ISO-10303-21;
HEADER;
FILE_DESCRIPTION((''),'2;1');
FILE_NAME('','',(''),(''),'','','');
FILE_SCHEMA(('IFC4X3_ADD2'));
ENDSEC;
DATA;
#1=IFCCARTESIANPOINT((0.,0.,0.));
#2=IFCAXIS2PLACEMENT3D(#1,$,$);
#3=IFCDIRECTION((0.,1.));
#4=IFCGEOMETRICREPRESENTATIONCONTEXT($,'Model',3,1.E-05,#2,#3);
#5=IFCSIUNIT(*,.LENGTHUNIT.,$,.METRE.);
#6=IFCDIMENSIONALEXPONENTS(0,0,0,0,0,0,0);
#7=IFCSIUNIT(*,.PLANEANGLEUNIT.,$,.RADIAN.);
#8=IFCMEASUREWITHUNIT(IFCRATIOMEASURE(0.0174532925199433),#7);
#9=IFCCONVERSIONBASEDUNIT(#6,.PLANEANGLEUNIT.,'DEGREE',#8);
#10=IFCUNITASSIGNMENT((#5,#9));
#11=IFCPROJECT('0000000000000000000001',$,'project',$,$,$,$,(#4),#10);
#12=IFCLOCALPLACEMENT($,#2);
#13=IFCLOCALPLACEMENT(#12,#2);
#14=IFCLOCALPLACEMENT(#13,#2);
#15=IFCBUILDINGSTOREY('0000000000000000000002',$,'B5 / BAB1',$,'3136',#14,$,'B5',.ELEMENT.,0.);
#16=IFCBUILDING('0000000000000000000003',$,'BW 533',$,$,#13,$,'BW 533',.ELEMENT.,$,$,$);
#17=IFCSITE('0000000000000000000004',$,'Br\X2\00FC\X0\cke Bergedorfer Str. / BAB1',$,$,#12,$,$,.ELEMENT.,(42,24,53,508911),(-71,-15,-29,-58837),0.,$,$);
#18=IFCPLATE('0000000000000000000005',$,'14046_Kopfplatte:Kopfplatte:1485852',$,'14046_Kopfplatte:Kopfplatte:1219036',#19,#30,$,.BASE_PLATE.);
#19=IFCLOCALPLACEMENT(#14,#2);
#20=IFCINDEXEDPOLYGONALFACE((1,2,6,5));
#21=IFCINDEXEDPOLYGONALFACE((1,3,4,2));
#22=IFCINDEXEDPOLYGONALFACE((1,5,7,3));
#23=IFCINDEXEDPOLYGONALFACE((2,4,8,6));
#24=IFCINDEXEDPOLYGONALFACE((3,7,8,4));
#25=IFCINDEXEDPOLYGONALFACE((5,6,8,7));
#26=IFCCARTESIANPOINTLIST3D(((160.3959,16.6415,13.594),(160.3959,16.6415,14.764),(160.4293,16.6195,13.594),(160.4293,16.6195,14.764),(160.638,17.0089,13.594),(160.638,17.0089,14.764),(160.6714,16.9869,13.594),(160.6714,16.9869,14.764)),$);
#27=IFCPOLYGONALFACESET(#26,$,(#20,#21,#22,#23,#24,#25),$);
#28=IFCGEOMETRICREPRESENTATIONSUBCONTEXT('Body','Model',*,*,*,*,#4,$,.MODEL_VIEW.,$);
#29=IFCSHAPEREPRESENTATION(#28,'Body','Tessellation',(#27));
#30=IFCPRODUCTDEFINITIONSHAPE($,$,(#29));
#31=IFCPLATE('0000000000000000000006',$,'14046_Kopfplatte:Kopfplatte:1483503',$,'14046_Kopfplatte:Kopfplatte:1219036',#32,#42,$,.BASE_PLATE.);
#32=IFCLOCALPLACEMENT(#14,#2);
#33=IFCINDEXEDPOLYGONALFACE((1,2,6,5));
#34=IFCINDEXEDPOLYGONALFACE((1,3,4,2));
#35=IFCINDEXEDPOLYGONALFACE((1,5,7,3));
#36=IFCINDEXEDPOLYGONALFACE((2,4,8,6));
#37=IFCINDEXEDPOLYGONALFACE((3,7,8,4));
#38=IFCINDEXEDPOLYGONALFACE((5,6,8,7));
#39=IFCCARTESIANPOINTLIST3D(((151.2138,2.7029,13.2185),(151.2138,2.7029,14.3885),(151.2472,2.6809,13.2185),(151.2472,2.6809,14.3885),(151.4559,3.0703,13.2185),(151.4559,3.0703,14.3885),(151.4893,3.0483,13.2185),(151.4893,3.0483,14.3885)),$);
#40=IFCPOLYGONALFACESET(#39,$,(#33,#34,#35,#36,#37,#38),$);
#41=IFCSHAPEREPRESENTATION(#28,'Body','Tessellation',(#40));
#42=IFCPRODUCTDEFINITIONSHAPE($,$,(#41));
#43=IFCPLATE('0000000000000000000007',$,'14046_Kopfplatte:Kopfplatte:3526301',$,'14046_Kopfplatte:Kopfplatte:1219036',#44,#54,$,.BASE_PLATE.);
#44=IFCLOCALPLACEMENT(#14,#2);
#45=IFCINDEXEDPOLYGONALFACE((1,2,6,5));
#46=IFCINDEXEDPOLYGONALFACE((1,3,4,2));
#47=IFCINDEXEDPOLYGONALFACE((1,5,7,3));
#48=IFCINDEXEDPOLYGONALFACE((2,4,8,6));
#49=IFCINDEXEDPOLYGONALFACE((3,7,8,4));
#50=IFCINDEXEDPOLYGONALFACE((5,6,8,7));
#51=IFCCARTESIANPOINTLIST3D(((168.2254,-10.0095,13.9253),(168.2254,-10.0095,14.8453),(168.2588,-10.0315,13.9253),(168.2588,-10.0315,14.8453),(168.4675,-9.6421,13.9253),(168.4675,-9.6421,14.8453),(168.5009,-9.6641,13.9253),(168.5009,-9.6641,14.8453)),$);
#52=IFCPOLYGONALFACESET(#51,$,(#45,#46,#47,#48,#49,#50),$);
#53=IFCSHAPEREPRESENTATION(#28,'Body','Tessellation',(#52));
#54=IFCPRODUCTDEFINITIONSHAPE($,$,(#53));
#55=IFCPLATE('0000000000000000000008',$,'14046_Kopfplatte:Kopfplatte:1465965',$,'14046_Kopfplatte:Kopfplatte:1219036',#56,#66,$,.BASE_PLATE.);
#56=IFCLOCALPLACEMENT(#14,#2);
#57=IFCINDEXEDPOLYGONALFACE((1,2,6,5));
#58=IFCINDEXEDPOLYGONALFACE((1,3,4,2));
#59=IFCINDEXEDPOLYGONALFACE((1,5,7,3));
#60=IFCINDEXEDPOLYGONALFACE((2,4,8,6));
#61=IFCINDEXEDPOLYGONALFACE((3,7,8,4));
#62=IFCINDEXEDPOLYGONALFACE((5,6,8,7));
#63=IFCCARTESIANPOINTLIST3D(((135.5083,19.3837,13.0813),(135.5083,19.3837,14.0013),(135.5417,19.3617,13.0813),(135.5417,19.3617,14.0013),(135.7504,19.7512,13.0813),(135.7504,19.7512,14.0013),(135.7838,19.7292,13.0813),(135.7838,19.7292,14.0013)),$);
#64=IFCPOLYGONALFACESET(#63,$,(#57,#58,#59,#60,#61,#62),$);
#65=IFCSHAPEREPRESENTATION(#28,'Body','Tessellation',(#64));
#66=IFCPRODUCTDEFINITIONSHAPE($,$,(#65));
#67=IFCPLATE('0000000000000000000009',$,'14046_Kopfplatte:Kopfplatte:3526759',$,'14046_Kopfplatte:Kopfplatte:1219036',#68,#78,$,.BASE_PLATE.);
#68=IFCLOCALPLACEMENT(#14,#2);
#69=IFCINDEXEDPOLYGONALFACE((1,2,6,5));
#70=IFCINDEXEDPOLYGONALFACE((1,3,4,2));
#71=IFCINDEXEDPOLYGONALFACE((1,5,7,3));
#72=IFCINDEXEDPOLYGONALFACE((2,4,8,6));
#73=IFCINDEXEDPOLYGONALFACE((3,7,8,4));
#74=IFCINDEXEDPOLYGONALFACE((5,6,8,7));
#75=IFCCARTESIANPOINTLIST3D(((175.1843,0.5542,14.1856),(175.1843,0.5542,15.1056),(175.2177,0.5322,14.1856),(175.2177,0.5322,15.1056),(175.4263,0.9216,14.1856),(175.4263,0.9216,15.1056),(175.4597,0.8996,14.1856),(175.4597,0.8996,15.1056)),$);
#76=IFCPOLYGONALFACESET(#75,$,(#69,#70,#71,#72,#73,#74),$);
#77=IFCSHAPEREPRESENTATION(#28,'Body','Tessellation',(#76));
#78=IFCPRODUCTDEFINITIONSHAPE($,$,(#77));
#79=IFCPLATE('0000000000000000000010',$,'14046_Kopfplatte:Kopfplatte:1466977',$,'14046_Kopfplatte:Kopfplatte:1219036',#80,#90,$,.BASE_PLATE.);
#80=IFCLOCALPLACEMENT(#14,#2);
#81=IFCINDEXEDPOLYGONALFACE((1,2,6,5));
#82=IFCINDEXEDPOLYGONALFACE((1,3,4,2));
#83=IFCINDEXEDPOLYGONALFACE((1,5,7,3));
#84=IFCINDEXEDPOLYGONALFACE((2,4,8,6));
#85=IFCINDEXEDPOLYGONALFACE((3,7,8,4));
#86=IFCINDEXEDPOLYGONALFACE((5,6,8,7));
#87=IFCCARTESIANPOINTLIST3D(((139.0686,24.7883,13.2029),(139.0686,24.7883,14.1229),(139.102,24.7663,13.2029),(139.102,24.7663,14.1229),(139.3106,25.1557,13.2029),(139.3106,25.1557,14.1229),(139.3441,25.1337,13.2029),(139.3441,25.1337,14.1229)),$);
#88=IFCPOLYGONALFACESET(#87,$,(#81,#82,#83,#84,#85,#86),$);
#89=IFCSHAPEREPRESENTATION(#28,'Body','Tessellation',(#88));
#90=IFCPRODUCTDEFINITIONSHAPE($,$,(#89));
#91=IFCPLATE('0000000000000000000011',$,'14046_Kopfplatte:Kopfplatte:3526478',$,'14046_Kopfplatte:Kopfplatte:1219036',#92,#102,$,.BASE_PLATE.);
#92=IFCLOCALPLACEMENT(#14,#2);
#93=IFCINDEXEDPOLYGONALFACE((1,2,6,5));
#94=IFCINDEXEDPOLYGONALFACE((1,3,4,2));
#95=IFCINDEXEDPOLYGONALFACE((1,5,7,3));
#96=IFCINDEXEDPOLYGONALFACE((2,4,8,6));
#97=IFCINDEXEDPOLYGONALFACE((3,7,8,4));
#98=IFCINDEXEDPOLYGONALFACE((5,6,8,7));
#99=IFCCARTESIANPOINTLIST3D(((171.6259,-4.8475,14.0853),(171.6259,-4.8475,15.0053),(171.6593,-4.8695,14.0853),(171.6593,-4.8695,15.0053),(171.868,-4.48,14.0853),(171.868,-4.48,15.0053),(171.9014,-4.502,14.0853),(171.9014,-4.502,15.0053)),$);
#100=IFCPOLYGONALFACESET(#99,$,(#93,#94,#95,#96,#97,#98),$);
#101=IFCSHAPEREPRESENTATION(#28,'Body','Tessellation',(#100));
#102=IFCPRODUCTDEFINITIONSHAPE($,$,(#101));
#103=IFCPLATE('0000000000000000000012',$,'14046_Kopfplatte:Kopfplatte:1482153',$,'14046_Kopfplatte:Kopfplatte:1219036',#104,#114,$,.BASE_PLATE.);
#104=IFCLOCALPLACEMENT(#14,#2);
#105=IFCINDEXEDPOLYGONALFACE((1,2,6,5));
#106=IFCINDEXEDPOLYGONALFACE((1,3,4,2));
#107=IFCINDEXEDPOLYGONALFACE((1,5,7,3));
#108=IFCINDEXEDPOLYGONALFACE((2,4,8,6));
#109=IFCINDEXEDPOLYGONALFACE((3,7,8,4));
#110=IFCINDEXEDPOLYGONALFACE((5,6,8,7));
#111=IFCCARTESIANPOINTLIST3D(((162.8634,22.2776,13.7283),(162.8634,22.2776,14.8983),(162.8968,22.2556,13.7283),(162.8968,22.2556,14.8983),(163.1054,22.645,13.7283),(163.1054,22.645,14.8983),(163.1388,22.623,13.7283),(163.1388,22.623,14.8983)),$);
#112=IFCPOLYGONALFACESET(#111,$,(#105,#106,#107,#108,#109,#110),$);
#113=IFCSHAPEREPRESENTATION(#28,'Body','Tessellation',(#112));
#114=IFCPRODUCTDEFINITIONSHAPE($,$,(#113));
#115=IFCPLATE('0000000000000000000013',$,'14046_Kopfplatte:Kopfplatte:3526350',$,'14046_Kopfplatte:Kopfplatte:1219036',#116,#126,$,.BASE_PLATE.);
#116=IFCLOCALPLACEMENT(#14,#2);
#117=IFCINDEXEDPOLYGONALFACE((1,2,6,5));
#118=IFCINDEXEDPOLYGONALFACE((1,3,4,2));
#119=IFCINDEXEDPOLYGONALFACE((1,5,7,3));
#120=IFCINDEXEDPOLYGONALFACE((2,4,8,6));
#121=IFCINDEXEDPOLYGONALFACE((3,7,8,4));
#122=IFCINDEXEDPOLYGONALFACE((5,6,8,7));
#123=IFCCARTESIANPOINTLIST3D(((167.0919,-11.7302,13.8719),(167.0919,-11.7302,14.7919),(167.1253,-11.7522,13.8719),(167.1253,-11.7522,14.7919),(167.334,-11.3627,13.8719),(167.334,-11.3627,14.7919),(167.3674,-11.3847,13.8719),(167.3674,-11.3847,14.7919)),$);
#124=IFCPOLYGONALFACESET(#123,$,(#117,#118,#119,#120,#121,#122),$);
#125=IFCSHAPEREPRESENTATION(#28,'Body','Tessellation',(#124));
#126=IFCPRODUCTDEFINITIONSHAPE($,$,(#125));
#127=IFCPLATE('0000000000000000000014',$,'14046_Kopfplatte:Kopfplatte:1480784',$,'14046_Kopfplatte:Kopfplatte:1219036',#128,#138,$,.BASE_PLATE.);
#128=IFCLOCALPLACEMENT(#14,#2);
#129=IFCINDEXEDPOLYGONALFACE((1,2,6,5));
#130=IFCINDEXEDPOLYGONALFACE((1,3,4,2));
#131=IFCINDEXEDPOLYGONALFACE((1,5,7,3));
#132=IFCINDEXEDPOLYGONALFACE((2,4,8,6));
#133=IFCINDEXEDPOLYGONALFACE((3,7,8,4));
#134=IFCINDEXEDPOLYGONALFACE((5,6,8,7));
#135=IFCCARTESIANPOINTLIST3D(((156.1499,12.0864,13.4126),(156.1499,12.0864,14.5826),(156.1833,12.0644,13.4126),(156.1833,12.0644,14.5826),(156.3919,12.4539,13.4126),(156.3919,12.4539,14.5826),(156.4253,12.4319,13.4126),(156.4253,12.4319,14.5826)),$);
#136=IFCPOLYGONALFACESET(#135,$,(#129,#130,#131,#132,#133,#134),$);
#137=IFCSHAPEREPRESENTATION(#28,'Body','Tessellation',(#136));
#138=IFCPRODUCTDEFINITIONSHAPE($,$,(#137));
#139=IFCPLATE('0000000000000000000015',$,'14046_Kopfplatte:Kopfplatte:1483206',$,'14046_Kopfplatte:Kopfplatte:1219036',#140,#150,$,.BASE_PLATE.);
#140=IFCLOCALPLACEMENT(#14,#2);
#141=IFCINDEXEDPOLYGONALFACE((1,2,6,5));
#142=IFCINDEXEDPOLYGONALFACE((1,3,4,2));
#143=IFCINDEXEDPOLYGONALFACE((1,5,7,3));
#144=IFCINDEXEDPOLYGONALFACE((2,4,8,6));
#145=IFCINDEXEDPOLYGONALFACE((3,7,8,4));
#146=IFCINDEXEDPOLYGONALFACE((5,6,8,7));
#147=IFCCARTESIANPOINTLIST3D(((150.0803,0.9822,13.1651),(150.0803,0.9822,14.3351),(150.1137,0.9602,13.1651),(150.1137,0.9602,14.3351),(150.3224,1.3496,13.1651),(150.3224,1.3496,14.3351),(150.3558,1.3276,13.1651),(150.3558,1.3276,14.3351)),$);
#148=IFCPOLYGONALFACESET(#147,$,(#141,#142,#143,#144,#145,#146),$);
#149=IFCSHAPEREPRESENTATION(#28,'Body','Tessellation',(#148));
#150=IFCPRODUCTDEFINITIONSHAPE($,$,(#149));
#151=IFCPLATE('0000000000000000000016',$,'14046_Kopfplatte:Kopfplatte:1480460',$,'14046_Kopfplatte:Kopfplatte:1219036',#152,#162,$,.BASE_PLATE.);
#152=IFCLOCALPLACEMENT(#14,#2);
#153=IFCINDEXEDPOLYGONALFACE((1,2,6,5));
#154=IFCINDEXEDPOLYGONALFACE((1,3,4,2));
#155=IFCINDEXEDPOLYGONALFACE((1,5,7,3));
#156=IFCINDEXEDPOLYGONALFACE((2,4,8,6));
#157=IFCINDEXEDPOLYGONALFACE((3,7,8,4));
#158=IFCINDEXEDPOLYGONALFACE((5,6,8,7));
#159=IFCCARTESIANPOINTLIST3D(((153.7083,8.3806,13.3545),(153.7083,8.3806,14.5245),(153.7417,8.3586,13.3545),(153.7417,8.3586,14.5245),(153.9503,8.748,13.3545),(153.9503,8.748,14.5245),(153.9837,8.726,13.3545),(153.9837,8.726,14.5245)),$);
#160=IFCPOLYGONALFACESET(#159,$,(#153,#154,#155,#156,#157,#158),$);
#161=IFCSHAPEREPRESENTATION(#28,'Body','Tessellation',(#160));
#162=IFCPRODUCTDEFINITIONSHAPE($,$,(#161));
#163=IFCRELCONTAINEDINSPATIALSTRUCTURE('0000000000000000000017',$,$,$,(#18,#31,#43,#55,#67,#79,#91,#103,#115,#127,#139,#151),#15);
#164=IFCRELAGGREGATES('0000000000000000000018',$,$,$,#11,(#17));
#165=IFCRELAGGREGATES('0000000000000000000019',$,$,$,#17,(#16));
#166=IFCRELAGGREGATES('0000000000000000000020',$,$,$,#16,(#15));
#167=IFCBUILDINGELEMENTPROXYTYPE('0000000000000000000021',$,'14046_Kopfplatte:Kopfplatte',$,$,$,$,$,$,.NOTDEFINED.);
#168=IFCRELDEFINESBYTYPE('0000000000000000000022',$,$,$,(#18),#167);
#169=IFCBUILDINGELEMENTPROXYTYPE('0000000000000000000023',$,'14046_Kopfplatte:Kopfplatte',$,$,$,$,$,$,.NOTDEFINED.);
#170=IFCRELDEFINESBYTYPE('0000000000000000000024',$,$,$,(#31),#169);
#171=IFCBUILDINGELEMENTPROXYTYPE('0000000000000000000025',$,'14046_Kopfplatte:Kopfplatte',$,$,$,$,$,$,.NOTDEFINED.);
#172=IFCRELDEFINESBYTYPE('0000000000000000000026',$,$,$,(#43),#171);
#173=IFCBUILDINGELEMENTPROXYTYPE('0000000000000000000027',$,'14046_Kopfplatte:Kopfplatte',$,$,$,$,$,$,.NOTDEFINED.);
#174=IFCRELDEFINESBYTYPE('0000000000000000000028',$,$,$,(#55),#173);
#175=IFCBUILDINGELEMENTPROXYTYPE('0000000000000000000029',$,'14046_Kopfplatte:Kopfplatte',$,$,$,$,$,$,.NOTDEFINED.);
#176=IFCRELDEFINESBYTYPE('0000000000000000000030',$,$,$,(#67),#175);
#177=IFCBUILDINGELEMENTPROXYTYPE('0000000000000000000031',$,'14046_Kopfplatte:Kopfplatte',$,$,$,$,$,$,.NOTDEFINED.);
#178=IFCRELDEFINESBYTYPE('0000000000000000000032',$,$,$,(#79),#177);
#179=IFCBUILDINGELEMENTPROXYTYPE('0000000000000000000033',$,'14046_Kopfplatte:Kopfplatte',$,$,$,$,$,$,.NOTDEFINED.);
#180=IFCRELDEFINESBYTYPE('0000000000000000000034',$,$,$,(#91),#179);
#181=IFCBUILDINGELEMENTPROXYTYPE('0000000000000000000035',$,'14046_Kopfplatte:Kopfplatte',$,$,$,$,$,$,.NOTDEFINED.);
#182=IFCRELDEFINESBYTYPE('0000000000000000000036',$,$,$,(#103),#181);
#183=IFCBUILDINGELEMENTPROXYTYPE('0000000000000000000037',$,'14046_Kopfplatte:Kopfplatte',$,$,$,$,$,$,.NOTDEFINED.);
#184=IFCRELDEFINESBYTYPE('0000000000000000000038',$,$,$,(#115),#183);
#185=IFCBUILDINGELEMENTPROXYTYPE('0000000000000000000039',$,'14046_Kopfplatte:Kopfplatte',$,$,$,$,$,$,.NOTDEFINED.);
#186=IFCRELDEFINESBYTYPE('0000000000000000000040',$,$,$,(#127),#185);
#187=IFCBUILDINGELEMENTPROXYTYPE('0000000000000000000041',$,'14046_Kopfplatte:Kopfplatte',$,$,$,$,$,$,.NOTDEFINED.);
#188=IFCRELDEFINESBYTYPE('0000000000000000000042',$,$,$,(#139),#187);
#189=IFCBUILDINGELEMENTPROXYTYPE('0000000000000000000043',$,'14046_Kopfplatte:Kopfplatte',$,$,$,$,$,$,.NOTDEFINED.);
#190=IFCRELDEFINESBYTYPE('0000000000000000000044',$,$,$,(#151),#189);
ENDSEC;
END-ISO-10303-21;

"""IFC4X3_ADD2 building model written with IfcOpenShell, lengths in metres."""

from ifc_helpers import new_model, entity, si_unit, converted_unit, direction, frame, frame_2d, origin, origin_2d_with_axis, place, context, subcontext, project, spatial, rectangle, extrude, source, transform, mapped, type_object, type_shapes, element, save


model = new_model("IFC4X3_ADD2")

# Units and contexts
model_context = context("Model", 3, precision=1e-05, world=origin(), true_north=direction((0.0, 1.0)))
body_context = subcontext(model_context, "Body", "Model", "MODEL_VIEW")
ifc_project = project(units=[si_unit("LENGTHUNIT", "METRE"), converted_unit("PLANEANGLEUNIT", "DEGREE", entity("IfcRatioMeasure", 0.0174532925199433), si_unit("PLANEANGLEUNIT", "RADIAN"), dimensions=[0, 0, 0, 0, 0, 0, 0])], contexts=[model_context])

# Site, building, storey
site_placement = place(None, origin())
site = spatial("IfcSite", under=ifc_project, at=site_placement, Name="Brücke Bergedorfer Str. / BAB1", CompositionType="ELEMENT", RefLatitude=(42, 24, 53, 508911), RefLongitude=(-71, -15, -29, -58837), RefElevation=0.0)
building_placement = place(site_placement, origin())
building = spatial("IfcBuilding", under=site, at=building_placement, Name="BW 533", LongName="BW 533", CompositionType="ELEMENT")
storey_placement = place(building_placement, origin())
storey = spatial("IfcBuildingStorey", under=building, at=storey_placement, Name="B5 / BAB1", ObjectType="3136", LongName="B5", CompositionType="ELEMENT", Elevation=0.0)

# Plates
building_element_proxy_type_1 = type_object("IfcBuildingElementProxyType", Name="14046_Kopfplatte:Kopfplatte", PredefinedType="NOTDEFINED")
shared_shape_1 = source(origin(), body_context, "Body", "SweptSolid", [
    extrude(rectangle(XDim=0.04, YDim=0.44, at=frame_2d((0.0, 0.0), x_axis=(1.0, 0.0))), frame((160.5336, 16.8142, 13.594), z_axis=(0.0, 0.0, 1.0), x_axis=(-0.835088, 0.550116, 0.0)), (0.0, 0.0, 1.0), 1.17),
])
type_shapes(building_element_proxy_type_1, [shared_shape_1])
plate_1_placement = place(storey_placement, origin())
element("IfcPlate", 1, at=plate_1_placement, inside=storey, type_object=building_element_proxy_type_1, Name="14046_Kopfplatte:Kopfplatte:1485852", ObjectType="14046_Kopfplatte:Kopfplatte:1219036", PredefinedType="BASE_PLATE", context=body_context, shape_type="MappedRepresentation", body=[
    mapped(shared_shape_1, transform((0.0, 0.0, 0.0), scale=1.0)),
])
building_element_proxy_type_2 = type_object("IfcBuildingElementProxyType", Name="14046_Kopfplatte:Kopfplatte", PredefinedType="NOTDEFINED")
shared_shape_2 = source(origin(), body_context, "Body", "SweptSolid", [
    extrude(rectangle(XDim=0.04, YDim=0.44, at=frame_2d((0.0, 0.0), x_axis=(1.0, 0.0))), frame((151.3516, 2.8756, 13.2185), z_axis=(0.0, 0.0, 1.0), x_axis=(-0.835088, 0.550116, 0.0)), (0.0, 0.0, 1.0), 1.17),
])
type_shapes(building_element_proxy_type_2, [shared_shape_2])
plate_2_placement = place(storey_placement, origin())
element("IfcPlate", 2, at=plate_2_placement, inside=storey, type_object=building_element_proxy_type_2, Name="14046_Kopfplatte:Kopfplatte:1483503", ObjectType="14046_Kopfplatte:Kopfplatte:1219036", PredefinedType="BASE_PLATE", context=body_context, shape_type="MappedRepresentation", body=[
    mapped(shared_shape_2, transform((0.0, 0.0, 0.0), scale=1.0)),
])
building_element_proxy_type_3 = type_object("IfcBuildingElementProxyType", Name="14046_Kopfplatte:Kopfplatte", PredefinedType="NOTDEFINED")
shared_shape_3 = source(origin(), body_context, "Body", "SweptSolid", [
    extrude(rectangle(XDim=0.04, YDim=0.44, at=frame_2d((0.0, 0.0), x_axis=(1.0, 0.0))), frame((168.3631, -9.8368, 13.9253), z_axis=(0.0, 0.0, 1.0), x_axis=(0.835088, -0.550116, 0.0)), (0.0, 0.0, 1.0), 0.92),
])
type_shapes(building_element_proxy_type_3, [shared_shape_3])
plate_3_placement = place(storey_placement, origin())
element("IfcPlate", 3, at=plate_3_placement, inside=storey, type_object=building_element_proxy_type_3, Name="14046_Kopfplatte:Kopfplatte:3526301", ObjectType="14046_Kopfplatte:Kopfplatte:1219036", PredefinedType="BASE_PLATE", context=body_context, shape_type="MappedRepresentation", body=[
    mapped(shared_shape_3, transform((0.0, 0.0, 0.0), scale=1.0)),
])
building_element_proxy_type_4 = type_object("IfcBuildingElementProxyType", Name="14046_Kopfplatte:Kopfplatte", PredefinedType="NOTDEFINED")
shared_shape_4 = source(origin(), body_context, "Body", "SweptSolid", [
    extrude(rectangle(XDim=0.04, YDim=0.44, at=frame_2d((0.0, 0.0), x_axis=(1.0, 0.0))), frame((135.6461, 19.5565, 13.0813), z_axis=(0.0, 0.0, 1.0), x_axis=(-0.835088, 0.550116, 0.0)), (0.0, 0.0, 1.0), 0.92),
])
type_shapes(building_element_proxy_type_4, [shared_shape_4])
plate_4_placement = place(storey_placement, origin())
element("IfcPlate", 4, at=plate_4_placement, inside=storey, type_object=building_element_proxy_type_4, Name="14046_Kopfplatte:Kopfplatte:1465965", ObjectType="14046_Kopfplatte:Kopfplatte:1219036", PredefinedType="BASE_PLATE", context=body_context, shape_type="MappedRepresentation", body=[
    mapped(shared_shape_4, transform((0.0, 0.0, 0.0), scale=1.0)),
])
building_element_proxy_type_5 = type_object("IfcBuildingElementProxyType", Name="14046_Kopfplatte:Kopfplatte", PredefinedType="NOTDEFINED")
shared_shape_5 = source(origin(), body_context, "Body", "SweptSolid", [
    extrude(rectangle(XDim=0.04, YDim=0.44, at=frame_2d((0.0, 0.0), x_axis=(1.0, 0.0))), frame((175.322, 0.7269, 14.1856), z_axis=(0.0, 0.0, 1.0), x_axis=(0.835088, -0.550116, 0.0)), (0.0, 0.0, 1.0), 0.92),
])
type_shapes(building_element_proxy_type_5, [shared_shape_5])
plate_5_placement = place(storey_placement, origin())
element("IfcPlate", 5, at=plate_5_placement, inside=storey, type_object=building_element_proxy_type_5, Name="14046_Kopfplatte:Kopfplatte:3526759", ObjectType="14046_Kopfplatte:Kopfplatte:1219036", PredefinedType="BASE_PLATE", context=body_context, shape_type="MappedRepresentation", body=[
    mapped(shared_shape_5, transform((0.0, 0.0, 0.0), scale=1.0)),
])
building_element_proxy_type_6 = type_object("IfcBuildingElementProxyType", Name="14046_Kopfplatte:Kopfplatte", PredefinedType="NOTDEFINED")
shared_shape_6 = source(origin(), body_context, "Body", "SweptSolid", [
    extrude(rectangle(XDim=0.04, YDim=0.44, at=frame_2d((0.0, 0.0), x_axis=(1.0, 0.0))), frame((139.2063, 24.961, 13.2029), z_axis=(0.0, 0.0, 1.0), x_axis=(-0.835088, 0.550116, 0.0)), (0.0, 0.0, 1.0), 0.92),
])
type_shapes(building_element_proxy_type_6, [shared_shape_6])
plate_6_placement = place(storey_placement, origin())
element("IfcPlate", 6, at=plate_6_placement, inside=storey, type_object=building_element_proxy_type_6, Name="14046_Kopfplatte:Kopfplatte:1466977", ObjectType="14046_Kopfplatte:Kopfplatte:1219036", PredefinedType="BASE_PLATE", context=body_context, shape_type="MappedRepresentation", body=[
    mapped(shared_shape_6, transform((0.0, 0.0, 0.0), scale=1.0)),
])
building_element_proxy_type_7 = type_object("IfcBuildingElementProxyType", Name="14046_Kopfplatte:Kopfplatte", PredefinedType="NOTDEFINED")
shared_shape_7 = source(origin(), body_context, "Body", "SweptSolid", [
    extrude(rectangle(XDim=0.04, YDim=0.44, at=frame_2d((0.0, 0.0), x_axis=(1.0, 0.0))), frame((171.7636, -4.6748, 14.0853), z_axis=(0.0, 0.0, 1.0), x_axis=(0.835088, -0.550116, 0.0)), (0.0, 0.0, 1.0), 0.92),
])
type_shapes(building_element_proxy_type_7, [shared_shape_7])
plate_7_placement = place(storey_placement, origin())
element("IfcPlate", 7, at=plate_7_placement, inside=storey, type_object=building_element_proxy_type_7, Name="14046_Kopfplatte:Kopfplatte:3526478", ObjectType="14046_Kopfplatte:Kopfplatte:1219036", PredefinedType="BASE_PLATE", context=body_context, shape_type="MappedRepresentation", body=[
    mapped(shared_shape_7, transform((0.0, 0.0, 0.0), scale=1.0)),
])
building_element_proxy_type_8 = type_object("IfcBuildingElementProxyType", Name="14046_Kopfplatte:Kopfplatte", PredefinedType="NOTDEFINED")
shared_shape_8 = source(origin(), body_context, "Body", "SweptSolid", [
    extrude(rectangle(XDim=0.04, YDim=0.44, at=frame_2d((0.0, 0.0), x_axis=(1.0, 0.0))), frame((163.0011, 22.4503, 13.7283), z_axis=(0.0, 0.0, 1.0), x_axis=(0.835088, -0.550116, 0.0)), (0.0, 0.0, 1.0), 1.17),
])
type_shapes(building_element_proxy_type_8, [shared_shape_8])
plate_8_placement = place(storey_placement, origin())
element("IfcPlate", 8, at=plate_8_placement, inside=storey, type_object=building_element_proxy_type_8, Name="14046_Kopfplatte:Kopfplatte:1482153", ObjectType="14046_Kopfplatte:Kopfplatte:1219036", PredefinedType="BASE_PLATE", context=body_context, shape_type="MappedRepresentation", body=[
    mapped(shared_shape_8, transform((0.0, 0.0, 0.0), scale=1.0)),
])
building_element_proxy_type_9 = type_object("IfcBuildingElementProxyType", Name="14046_Kopfplatte:Kopfplatte", PredefinedType="NOTDEFINED")
shared_shape_9 = source(origin(), body_context, "Body", "SweptSolid", [
    extrude(rectangle(XDim=0.04, YDim=0.44, at=frame_2d((0.0, 0.0), x_axis=(1.0, 0.0))), frame((167.2296, -11.5575, 13.8719), z_axis=(0.0, 0.0, 1.0), x_axis=(0.835088, -0.550116, 0.0)), (0.0, 0.0, 1.0), 0.92),
])
type_shapes(building_element_proxy_type_9, [shared_shape_9])
plate_9_placement = place(storey_placement, origin())
element("IfcPlate", 9, at=plate_9_placement, inside=storey, type_object=building_element_proxy_type_9, Name="14046_Kopfplatte:Kopfplatte:3526350", ObjectType="14046_Kopfplatte:Kopfplatte:1219036", PredefinedType="BASE_PLATE", context=body_context, shape_type="MappedRepresentation", body=[
    mapped(shared_shape_9, transform((0.0, 0.0, 0.0), scale=1.0)),
])
building_element_proxy_type_10 = type_object("IfcBuildingElementProxyType", Name="14046_Kopfplatte:Kopfplatte", PredefinedType="NOTDEFINED")
shared_shape_10 = source(origin(), body_context, "Body", "SweptSolid", [
    extrude(rectangle(XDim=0.04, YDim=0.44, at=frame_2d((0.0, 0.0), x_axis=(1.0, 0.0))), frame((156.2876, 12.2592, 13.4126), z_axis=(0.0, 0.0, 1.0), x_axis=(0.835088, -0.550116, 0.0)), (0.0, 0.0, 1.0), 1.17),
])
type_shapes(building_element_proxy_type_10, [shared_shape_10])
plate_10_placement = place(storey_placement, origin())
element("IfcPlate", 10, at=plate_10_placement, inside=storey, type_object=building_element_proxy_type_10, Name="14046_Kopfplatte:Kopfplatte:1480784", ObjectType="14046_Kopfplatte:Kopfplatte:1219036", PredefinedType="BASE_PLATE", context=body_context, shape_type="MappedRepresentation", body=[
    mapped(shared_shape_10, transform((0.0, 0.0, 0.0), scale=1.0)),
])
building_element_proxy_type_11 = type_object("IfcBuildingElementProxyType", Name="14046_Kopfplatte:Kopfplatte", PredefinedType="NOTDEFINED")
shared_shape_11 = source(origin(), body_context, "Body", "SweptSolid", [
    extrude(rectangle(XDim=0.04, YDim=0.44, at=origin_2d_with_axis()), frame((150.2181, 1.1549, 13.1651), z_axis=(0.0, 0.0, 1.0), x_axis=(-0.835088, 0.550116, 0.0)), (0.0, 0.0, 1.0), 1.17),
])
type_shapes(building_element_proxy_type_11, [shared_shape_11])
plate_11_placement = place(storey_placement, origin())
element("IfcPlate", 11, at=plate_11_placement, inside=storey, type_object=building_element_proxy_type_11, Name="14046_Kopfplatte:Kopfplatte:1483206", ObjectType="14046_Kopfplatte:Kopfplatte:1219036", PredefinedType="BASE_PLATE", context=body_context, shape_type="MappedRepresentation", body=[
    mapped(shared_shape_11, transform((0.0, 0.0, 0.0), scale=1.0)),
])
building_element_proxy_type_12 = type_object("IfcBuildingElementProxyType", Name="14046_Kopfplatte:Kopfplatte", PredefinedType="NOTDEFINED")
shared_shape_12 = source(origin(), body_context, "Body", "SweptSolid", [
    extrude(rectangle(XDim=0.04, YDim=0.44, at=origin_2d_with_axis()), frame((153.846, 8.5533, 13.3545), z_axis=(0.0, 0.0, 1.0), x_axis=(0.835088, -0.550116, 0.0)), (0.0, 0.0, 1.0), 1.17),
])
type_shapes(building_element_proxy_type_12, [shared_shape_12])
plate_12_placement = place(storey_placement, origin())
element("IfcPlate", 12, at=plate_12_placement, inside=storey, type_object=building_element_proxy_type_12, Name="14046_Kopfplatte:Kopfplatte:1480460", ObjectType="14046_Kopfplatte:Kopfplatte:1219036", PredefinedType="BASE_PLATE", context=body_context, shape_type="MappedRepresentation", body=[
    mapped(shared_shape_12, transform((0.0, 0.0, 0.0), scale=1.0)),
])

save(model, "model.ifc")
